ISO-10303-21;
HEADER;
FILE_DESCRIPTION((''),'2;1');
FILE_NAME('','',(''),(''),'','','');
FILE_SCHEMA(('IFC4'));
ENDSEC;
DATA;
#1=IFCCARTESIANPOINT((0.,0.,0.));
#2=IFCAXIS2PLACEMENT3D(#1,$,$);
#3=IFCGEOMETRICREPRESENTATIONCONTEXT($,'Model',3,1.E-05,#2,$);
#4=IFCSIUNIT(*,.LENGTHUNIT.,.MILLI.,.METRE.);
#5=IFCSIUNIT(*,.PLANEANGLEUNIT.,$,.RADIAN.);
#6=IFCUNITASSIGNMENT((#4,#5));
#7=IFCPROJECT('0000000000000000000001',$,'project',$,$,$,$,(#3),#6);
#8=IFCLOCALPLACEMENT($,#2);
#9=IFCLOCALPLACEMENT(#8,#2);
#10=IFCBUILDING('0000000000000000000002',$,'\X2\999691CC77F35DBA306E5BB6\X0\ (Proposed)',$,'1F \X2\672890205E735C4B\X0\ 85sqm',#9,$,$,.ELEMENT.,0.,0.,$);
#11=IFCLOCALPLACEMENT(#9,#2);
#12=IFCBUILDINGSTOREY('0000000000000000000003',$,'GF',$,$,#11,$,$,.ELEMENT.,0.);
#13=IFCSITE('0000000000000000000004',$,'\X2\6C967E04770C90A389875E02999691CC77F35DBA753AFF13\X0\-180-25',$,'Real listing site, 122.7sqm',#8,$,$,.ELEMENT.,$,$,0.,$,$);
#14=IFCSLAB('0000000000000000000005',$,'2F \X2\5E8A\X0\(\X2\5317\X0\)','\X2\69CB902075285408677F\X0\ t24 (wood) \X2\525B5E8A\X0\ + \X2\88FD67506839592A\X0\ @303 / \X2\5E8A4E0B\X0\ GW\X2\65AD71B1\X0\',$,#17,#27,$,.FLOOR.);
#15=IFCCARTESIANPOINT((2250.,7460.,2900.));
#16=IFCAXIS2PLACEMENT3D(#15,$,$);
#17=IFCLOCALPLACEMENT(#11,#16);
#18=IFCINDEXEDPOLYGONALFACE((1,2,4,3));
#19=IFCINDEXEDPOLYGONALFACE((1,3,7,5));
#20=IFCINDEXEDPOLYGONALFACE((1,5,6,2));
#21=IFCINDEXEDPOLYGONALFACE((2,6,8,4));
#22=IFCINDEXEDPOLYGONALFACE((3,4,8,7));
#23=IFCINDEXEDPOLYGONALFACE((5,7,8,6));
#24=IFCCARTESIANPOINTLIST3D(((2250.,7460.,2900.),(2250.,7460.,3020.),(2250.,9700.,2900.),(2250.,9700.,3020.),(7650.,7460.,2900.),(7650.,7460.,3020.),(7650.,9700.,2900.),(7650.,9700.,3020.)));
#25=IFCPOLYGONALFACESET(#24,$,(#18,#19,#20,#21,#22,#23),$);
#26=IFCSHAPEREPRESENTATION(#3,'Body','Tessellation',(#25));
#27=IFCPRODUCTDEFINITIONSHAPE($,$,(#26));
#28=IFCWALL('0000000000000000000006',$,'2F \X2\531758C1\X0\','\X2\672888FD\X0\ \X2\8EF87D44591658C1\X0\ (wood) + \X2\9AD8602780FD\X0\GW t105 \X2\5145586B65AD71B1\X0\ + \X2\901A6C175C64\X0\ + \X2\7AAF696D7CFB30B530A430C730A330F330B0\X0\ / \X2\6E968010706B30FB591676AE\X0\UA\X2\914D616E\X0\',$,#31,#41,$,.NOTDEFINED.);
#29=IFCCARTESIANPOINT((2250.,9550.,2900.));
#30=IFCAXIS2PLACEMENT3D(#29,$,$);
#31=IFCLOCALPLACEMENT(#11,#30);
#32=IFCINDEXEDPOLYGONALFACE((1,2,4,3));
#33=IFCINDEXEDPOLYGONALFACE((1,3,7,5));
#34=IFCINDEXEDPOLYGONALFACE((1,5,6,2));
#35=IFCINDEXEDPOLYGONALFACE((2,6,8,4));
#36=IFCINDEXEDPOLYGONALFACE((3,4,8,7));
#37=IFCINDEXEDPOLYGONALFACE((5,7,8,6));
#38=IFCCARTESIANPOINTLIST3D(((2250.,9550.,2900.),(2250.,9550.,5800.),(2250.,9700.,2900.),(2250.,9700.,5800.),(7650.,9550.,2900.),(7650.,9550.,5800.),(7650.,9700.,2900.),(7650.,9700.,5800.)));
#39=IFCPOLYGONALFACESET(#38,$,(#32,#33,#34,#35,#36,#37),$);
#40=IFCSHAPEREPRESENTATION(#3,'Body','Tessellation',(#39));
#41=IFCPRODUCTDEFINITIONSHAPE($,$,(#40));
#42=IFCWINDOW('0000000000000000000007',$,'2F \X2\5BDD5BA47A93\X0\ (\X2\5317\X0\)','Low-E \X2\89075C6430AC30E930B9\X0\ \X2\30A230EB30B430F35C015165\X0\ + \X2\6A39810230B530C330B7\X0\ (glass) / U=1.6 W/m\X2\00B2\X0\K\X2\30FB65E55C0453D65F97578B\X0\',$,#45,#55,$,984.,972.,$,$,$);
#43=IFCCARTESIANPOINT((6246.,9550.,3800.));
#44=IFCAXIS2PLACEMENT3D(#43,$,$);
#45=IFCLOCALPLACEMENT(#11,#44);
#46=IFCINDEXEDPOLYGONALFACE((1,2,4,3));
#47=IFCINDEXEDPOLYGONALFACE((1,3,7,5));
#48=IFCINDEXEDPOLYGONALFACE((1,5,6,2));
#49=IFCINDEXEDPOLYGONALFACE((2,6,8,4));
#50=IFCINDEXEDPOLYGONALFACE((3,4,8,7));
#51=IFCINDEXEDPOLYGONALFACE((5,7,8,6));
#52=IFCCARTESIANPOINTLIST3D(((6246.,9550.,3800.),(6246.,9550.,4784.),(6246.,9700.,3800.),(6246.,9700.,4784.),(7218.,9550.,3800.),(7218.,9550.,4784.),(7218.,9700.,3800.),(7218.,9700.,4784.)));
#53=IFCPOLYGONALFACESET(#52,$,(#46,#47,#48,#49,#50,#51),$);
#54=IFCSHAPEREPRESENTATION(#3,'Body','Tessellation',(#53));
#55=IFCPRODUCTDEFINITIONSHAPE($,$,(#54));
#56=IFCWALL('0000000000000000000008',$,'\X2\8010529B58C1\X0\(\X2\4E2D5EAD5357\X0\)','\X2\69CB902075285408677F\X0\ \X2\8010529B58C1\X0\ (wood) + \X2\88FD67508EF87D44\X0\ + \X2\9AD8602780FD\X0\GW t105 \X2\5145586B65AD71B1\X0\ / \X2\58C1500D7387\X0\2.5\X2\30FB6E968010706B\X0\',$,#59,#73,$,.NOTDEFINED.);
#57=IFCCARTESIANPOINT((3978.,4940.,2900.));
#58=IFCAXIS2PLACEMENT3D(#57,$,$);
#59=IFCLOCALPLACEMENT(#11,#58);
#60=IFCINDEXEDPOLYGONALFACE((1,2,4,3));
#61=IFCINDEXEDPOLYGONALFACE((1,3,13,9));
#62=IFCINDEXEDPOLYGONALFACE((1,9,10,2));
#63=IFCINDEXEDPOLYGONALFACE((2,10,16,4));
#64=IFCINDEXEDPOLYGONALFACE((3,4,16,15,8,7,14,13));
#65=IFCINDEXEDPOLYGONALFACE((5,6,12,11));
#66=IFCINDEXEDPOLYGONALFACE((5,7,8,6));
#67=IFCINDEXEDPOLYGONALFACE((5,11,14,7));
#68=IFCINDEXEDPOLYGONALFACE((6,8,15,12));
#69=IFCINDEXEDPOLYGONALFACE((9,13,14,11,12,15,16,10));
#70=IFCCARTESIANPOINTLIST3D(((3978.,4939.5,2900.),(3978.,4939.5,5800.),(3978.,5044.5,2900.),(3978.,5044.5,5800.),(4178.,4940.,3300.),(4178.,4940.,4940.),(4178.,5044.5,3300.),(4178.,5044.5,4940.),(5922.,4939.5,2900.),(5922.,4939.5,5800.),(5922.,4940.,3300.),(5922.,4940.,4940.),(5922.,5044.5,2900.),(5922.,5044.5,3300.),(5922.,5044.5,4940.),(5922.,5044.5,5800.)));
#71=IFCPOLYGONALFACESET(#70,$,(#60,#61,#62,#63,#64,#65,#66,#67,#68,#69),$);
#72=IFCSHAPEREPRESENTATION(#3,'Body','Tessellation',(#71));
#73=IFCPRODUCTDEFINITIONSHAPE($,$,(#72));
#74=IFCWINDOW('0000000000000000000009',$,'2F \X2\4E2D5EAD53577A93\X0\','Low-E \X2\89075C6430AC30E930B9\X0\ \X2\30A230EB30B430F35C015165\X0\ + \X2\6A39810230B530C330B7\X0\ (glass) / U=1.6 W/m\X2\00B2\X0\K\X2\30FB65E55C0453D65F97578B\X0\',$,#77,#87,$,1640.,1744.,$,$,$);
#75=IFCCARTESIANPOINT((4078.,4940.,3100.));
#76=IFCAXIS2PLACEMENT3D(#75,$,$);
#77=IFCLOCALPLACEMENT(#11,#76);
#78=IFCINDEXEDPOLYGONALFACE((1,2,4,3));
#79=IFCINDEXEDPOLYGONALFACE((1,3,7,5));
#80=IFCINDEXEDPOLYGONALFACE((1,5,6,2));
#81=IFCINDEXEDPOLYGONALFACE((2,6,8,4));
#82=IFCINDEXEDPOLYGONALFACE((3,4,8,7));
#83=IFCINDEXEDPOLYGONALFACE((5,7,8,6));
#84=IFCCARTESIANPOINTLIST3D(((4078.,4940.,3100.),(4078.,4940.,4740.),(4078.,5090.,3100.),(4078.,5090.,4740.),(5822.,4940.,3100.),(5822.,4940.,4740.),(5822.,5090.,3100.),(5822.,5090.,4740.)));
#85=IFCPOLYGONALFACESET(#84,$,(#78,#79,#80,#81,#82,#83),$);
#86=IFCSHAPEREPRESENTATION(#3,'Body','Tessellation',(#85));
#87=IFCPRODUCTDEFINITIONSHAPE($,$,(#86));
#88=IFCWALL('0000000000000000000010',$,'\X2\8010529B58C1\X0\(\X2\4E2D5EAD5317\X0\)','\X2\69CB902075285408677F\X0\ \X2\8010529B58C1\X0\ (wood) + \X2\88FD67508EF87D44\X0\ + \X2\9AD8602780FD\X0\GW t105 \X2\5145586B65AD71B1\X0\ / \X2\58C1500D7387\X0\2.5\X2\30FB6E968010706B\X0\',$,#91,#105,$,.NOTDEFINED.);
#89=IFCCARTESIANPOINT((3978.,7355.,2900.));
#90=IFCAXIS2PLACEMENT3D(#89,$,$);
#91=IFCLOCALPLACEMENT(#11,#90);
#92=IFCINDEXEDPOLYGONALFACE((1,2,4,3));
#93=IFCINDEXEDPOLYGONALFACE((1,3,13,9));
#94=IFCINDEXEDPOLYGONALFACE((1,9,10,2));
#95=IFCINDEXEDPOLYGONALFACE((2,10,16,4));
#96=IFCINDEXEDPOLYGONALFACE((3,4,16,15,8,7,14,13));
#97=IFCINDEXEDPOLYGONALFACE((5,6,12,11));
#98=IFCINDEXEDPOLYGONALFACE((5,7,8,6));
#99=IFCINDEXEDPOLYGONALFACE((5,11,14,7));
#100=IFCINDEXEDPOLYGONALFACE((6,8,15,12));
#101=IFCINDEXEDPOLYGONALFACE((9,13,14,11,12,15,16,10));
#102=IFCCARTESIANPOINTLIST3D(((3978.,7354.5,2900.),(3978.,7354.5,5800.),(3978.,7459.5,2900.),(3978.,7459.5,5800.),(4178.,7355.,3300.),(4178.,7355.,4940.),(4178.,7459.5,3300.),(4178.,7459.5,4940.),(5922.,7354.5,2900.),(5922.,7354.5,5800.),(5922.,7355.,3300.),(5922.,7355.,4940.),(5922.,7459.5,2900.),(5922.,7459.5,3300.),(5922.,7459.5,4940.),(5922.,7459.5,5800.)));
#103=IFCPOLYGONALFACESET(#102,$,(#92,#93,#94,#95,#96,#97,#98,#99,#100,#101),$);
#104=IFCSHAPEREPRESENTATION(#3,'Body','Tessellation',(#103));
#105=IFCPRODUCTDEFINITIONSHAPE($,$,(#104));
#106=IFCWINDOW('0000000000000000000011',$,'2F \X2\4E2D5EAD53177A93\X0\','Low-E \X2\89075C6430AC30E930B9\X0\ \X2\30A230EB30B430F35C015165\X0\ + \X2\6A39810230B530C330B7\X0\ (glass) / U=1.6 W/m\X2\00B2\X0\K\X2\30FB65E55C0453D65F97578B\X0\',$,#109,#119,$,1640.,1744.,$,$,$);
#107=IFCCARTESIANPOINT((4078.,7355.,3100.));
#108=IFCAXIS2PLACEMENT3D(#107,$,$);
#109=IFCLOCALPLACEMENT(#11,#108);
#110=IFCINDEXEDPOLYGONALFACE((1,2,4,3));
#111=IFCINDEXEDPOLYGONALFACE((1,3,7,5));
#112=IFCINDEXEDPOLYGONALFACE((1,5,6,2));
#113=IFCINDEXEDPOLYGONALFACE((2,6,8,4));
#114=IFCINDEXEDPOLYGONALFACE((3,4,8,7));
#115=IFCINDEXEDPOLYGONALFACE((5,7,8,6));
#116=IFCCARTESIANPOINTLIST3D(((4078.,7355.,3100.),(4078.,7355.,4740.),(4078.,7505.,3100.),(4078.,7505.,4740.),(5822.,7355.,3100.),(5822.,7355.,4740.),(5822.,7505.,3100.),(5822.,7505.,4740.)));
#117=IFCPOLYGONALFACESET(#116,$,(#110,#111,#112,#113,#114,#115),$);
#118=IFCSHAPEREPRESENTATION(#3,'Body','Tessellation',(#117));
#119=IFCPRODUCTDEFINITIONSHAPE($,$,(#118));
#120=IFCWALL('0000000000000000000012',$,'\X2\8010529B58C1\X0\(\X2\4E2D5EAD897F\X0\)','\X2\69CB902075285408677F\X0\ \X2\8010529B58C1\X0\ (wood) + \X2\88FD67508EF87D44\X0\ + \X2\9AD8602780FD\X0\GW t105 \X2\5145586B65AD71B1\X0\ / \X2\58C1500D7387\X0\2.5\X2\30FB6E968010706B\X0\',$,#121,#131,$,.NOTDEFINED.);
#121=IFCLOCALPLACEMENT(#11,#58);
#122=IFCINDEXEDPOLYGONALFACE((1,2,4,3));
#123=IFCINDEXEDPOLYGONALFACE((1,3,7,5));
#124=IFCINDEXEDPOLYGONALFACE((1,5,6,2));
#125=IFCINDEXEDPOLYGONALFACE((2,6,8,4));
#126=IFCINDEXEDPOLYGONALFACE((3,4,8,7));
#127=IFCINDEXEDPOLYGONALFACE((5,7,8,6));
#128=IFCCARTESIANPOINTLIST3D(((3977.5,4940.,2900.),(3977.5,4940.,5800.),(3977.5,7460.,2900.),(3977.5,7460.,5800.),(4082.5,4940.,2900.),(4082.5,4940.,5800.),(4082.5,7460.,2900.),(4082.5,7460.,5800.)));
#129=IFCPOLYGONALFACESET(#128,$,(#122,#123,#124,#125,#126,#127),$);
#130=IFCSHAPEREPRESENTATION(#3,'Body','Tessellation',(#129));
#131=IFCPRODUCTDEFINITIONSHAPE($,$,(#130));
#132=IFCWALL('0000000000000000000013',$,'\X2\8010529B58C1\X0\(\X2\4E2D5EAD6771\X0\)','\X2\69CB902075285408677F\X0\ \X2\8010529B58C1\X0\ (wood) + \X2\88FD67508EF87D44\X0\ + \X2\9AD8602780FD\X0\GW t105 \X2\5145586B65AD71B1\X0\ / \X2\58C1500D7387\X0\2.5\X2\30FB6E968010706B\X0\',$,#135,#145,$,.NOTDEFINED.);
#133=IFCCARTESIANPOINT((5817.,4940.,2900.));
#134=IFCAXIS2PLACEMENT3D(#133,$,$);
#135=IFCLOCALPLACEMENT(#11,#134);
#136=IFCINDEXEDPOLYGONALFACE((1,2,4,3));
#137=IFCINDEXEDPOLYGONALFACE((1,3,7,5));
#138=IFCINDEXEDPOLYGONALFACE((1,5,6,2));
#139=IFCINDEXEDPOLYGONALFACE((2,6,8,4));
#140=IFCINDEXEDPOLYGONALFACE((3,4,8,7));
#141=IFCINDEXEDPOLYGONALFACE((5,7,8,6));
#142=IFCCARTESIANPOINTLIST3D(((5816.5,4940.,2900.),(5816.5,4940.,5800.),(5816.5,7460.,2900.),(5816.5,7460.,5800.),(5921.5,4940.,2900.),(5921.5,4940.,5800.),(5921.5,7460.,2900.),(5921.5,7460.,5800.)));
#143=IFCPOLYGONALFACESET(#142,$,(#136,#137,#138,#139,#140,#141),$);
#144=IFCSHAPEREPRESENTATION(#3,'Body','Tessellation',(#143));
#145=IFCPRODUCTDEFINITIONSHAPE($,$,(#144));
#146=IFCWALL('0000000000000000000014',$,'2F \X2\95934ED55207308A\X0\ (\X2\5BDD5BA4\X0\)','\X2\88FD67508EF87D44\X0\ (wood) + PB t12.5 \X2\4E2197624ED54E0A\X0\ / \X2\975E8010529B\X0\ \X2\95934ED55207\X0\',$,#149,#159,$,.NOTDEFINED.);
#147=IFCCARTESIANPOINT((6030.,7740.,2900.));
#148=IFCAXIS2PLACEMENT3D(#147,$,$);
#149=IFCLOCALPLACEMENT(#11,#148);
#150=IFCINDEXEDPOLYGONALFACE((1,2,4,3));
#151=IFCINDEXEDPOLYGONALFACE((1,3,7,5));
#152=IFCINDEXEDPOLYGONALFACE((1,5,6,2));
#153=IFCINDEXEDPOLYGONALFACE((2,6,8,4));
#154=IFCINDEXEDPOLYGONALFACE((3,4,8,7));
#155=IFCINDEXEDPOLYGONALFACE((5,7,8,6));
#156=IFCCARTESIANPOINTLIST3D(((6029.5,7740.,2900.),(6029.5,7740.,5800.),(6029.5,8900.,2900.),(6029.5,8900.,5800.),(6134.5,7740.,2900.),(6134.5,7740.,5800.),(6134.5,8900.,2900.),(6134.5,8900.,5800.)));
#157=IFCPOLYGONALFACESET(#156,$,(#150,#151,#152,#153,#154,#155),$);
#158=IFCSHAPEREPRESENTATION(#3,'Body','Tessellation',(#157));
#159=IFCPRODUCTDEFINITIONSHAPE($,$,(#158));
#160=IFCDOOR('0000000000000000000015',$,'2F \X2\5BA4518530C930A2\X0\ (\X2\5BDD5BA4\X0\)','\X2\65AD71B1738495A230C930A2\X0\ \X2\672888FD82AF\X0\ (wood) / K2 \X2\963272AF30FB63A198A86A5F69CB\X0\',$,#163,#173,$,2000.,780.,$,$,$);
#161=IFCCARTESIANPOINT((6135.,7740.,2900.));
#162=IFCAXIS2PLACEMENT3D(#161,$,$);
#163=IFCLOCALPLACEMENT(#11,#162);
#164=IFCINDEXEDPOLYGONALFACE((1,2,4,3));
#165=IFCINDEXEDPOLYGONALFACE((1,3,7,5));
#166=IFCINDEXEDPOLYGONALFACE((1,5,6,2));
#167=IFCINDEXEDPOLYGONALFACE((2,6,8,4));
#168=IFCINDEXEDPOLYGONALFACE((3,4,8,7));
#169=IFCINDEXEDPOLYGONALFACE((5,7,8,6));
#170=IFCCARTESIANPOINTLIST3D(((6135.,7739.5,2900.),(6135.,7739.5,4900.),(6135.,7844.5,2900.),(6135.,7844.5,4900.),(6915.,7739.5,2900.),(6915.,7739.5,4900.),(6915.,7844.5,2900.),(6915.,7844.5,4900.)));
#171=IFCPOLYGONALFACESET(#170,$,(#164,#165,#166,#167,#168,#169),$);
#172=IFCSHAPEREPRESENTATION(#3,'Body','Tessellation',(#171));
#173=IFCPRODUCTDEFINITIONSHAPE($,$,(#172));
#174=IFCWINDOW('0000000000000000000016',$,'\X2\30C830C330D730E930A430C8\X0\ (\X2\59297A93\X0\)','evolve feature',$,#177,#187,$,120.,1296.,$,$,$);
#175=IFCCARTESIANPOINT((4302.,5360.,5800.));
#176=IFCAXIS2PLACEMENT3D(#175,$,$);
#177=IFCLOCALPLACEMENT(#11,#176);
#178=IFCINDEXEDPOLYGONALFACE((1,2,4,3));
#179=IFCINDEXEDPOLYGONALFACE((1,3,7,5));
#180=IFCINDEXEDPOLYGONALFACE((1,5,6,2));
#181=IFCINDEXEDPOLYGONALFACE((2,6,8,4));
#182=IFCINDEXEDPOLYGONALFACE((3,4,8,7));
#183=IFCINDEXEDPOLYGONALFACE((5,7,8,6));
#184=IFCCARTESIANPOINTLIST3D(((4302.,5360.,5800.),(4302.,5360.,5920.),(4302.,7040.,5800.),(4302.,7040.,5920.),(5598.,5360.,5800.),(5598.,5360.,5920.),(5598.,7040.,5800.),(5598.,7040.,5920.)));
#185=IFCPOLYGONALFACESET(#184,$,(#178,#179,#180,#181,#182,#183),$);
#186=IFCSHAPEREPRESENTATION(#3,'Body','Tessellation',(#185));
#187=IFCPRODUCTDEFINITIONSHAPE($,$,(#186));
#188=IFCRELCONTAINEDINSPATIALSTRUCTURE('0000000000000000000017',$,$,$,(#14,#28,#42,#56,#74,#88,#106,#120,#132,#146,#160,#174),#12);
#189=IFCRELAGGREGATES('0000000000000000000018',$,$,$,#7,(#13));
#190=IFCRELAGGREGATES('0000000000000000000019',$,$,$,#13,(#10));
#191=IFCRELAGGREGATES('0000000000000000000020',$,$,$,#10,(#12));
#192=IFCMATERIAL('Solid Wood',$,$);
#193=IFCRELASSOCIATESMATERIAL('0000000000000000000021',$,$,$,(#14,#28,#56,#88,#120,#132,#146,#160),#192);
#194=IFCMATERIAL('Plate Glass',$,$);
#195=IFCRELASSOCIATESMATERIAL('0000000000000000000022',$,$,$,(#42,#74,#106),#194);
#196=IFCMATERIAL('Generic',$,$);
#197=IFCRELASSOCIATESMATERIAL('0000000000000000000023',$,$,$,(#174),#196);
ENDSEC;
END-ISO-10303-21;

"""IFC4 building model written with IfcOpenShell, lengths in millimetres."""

from ifc_helpers import new_model, si_unit, frame, frame_2d, origin, place, context, project, spatial, rectangle, extrude, material, element, fill, save


model = new_model("IFC4")

# Units and contexts
model_context = context("Model", 3, precision=1e-05, world=origin())
ifc_project = project(units=[si_unit("LENGTHUNIT", "METRE", prefix="MILLI"), si_unit("PLANEANGLEUNIT", "RADIAN")], contexts=[model_context])

# Site, building, storey
site_placement = place(None, origin())
site = spatial("IfcSite", under=ifc_project, at=site_placement, Name="沖縄県那覇市首里石嶺町３-180-25", ObjectType="Real listing site, 122.7sqm", CompositionType="ELEMENT", RefElevation=0.0)
building_placement = place(site_placement, origin())
building = spatial("IfcBuilding", under=site, at=building_placement, Name="首里石嶺の家 (Proposed)", ObjectType="1F 木造平屋 85sqm", CompositionType="ELEMENT", ElevationOfRefHeight=0.0, ElevationOfTerrain=0.0)
storey_placement = place(building_placement, origin())
storey = spatial("IfcBuildingStorey", under=building, at=storey_placement, Name="GF", CompositionType="ELEMENT", Elevation=0.0)

# Slab
ifc_material_1 = material(Name="Solid Wood")
slab_placement = place(storey_placement, frame((2250.0, 7460.0, 2900.0)))
element("IfcSlab", 1, at=slab_placement, inside=storey, material=ifc_material_1, Name="2F 床(北)", Description="構造用合板 t24 (wood) 剛床 + 製材根太 @303 / 床下 GW断熱", PredefinedType="FLOOR", context=model_context, shape_type="SweptSolid", body=[
    extrude(rectangle(XDim=5400.0, YDim=2240.0, at=frame_2d((2700.0, 1120.0))), frame((2250.0, 7460.0, 2900.0)), (0.0, 0.0, 1.0), 120.0),
])

# Walls, openings, windows
wall_1_placement = place(storey_placement, frame((2250.0, 9550.0, 2900.0)))
wall_1 = element("IfcWall", 2, at=wall_1_placement, inside=storey, material=ifc_material_1, Name="2F 北壁", Description="木製 軸組外壁 (wood) + 高性能GW t105 充填断熱 + 通気層 + 窯業系サイディング / 準耐火・外皮UA配慮", PredefinedType="NOTDEFINED", context=model_context, shape_type="SweptSolid", body=[
    extrude(rectangle(XDim=5400.0, YDim=150.0, at=frame_2d((2700.0, 75.0))), frame((2250.0, 9550.0, 2900.0)), (0.0, 0.0, 1.0), 2900.0),
])
opening_1_placement = place(storey_placement, frame((6246.0, 9550.0, 3800.0)))
opening_1 = element("IfcOpeningElement", 3, at=opening_1_placement, cuts=wall_1, PredefinedType="NOTDEFINED", context=model_context, shape_type="SweptSolid", body=[
    extrude(rectangle(XDim=972.0, YDim=150.0, at=frame_2d((486.0, 75.0))), frame((6246.0, 9550.0, 3800.0)), (0.0, 0.0, 1.0), 984.0),
])
ifc_material_2 = material(Name="Plate Glass")
window_1_placement = place(storey_placement, frame((6246.0, 9550.0, 3800.0)))
window_1 = element("IfcWindow", 4, at=window_1_placement, inside=storey, material=ifc_material_2, Name="2F 寝室窓 (北)", Description="Low-E 複層ガラス アルゴン封入 + 樹脂サッシ (glass) / U=1.6 W/m²K・日射取得型", OverallHeight=984.0, OverallWidth=972.0, context=model_context, shape_type="SweptSolid", body=[
    extrude(rectangle(XDim=972.0, YDim=150.0, at=frame_2d((486.0, 75.0))), frame((6246.0, 9550.0, 3800.0)), (0.0, 0.0, 1.0), 984.0),
])
fill(opening_1, window_1)
wall_2_placement = place(storey_placement, frame((3978.0, 4940.0, 2900.0)))
wall_2 = element("IfcWall", 5, at=wall_2_placement, inside=storey, material=ifc_material_1, Name="耐力壁(中庭南)", Description="構造用合板 耐力壁 (wood) + 製材軸組 + 高性能GW t105 充填断熱 / 壁倍率2.5・準耐火", PredefinedType="NOTDEFINED", context=model_context, shape_type="SweptSolid", body=[
    extrude(rectangle(XDim=1944.0, YDim=105.0, at=frame_2d((972.0, 52.0))), frame((3978.0, 4940.0, 2900.0)), (0.0, 0.0, 1.0), 2900.0),
])
opening_2_placement = place(storey_placement, frame((4078.0, 4940.0, 3100.0)))
opening_2 = element("IfcOpeningElement", 6, at=opening_2_placement, cuts=wall_2, PredefinedType="NOTDEFINED", context=model_context, shape_type="SweptSolid", body=[
    extrude(rectangle(XDim=1744.0, YDim=150.0, at=frame_2d((872.0, 75.0))), frame((4078.0, 4940.0, 3100.0)), (0.0, 0.0, 1.0), 1640.0),
])
window_2_placement = place(storey_placement, frame((4078.0, 4940.0, 3100.0)))
window_2 = element("IfcWindow", 7, at=window_2_placement, inside=storey, material=ifc_material_2, Name="2F 中庭南窓", Description="Low-E 複層ガラス アルゴン封入 + 樹脂サッシ (glass) / U=1.6 W/m²K・日射取得型", OverallHeight=1640.0, OverallWidth=1744.0, context=model_context, shape_type="SweptSolid", body=[
    extrude(rectangle(XDim=1744.0, YDim=150.0, at=frame_2d((872.0, 75.0))), frame((4078.0, 4940.0, 3100.0)), (0.0, 0.0, 1.0), 1640.0),
])
fill(opening_2, window_2)
wall_3_placement = place(storey_placement, frame((3978.0, 7355.0, 2900.0)))
wall_3 = element("IfcWall", 8, at=wall_3_placement, inside=storey, material=ifc_material_1, Name="耐力壁(中庭北)", Description="構造用合板 耐力壁 (wood) + 製材軸組 + 高性能GW t105 充填断熱 / 壁倍率2.5・準耐火", PredefinedType="NOTDEFINED", context=model_context, shape_type="SweptSolid", body=[
    extrude(rectangle(XDim=1944.0, YDim=105.0, at=frame_2d((972.0, 52.0))), frame((3978.0, 7355.0, 2900.0)), (0.0, 0.0, 1.0), 2900.0),
])
opening_3_placement = place(storey_placement, frame((4078.0, 7355.0, 3100.0)))
opening_3 = element("IfcOpeningElement", 9, at=opening_3_placement, cuts=wall_3, PredefinedType="NOTDEFINED", context=model_context, shape_type="SweptSolid", body=[
    extrude(rectangle(XDim=1744.0, YDim=150.0, at=frame_2d((872.0, 75.0))), frame((4078.0, 7355.0, 3100.0)), (0.0, 0.0, 1.0), 1640.0),
])
window_3_placement = place(storey_placement, frame((4078.0, 7355.0, 3100.0)))
window_3 = element("IfcWindow", 10, at=window_3_placement, inside=storey, material=ifc_material_2, Name="2F 中庭北窓", Description="Low-E 複層ガラス アルゴン封入 + 樹脂サッシ (glass) / U=1.6 W/m²K・日射取得型", OverallHeight=1640.0, OverallWidth=1744.0, context=model_context, shape_type="SweptSolid", body=[
    extrude(rectangle(XDim=1744.0, YDim=150.0, at=frame_2d((872.0, 75.0))), frame((4078.0, 7355.0, 3100.0)), (0.0, 0.0, 1.0), 1640.0),
])
fill(opening_3, window_3)

# Walls
wall_4_placement = place(storey_placement, frame((3978.0, 4940.0, 2900.0)))
element("IfcWall", 11, at=wall_4_placement, inside=storey, material=ifc_material_1, Name="耐力壁(中庭西)", Description="構造用合板 耐力壁 (wood) + 製材軸組 + 高性能GW t105 充填断熱 / 壁倍率2.5・準耐火", PredefinedType="NOTDEFINED", context=model_context, shape_type="SweptSolid", body=[
    extrude(rectangle(XDim=105.0, YDim=2520.0, at=frame_2d((52.0, 1260.0))), frame((3978.0, 4940.0, 2900.0)), (0.0, 0.0, 1.0), 2900.0),
])
wall_5_placement = place(storey_placement, frame((5817.0, 4940.0, 2900.0)))
element("IfcWall", 12, at=wall_5_placement, inside=storey, material=ifc_material_1, Name="耐力壁(中庭東)", Description="構造用合板 耐力壁 (wood) + 製材軸組 + 高性能GW t105 充填断熱 / 壁倍率2.5・準耐火", PredefinedType="NOTDEFINED", context=model_context, shape_type="SweptSolid", body=[
    extrude(rectangle(XDim=105.0, YDim=2520.0, at=frame_2d((52.0, 1260.0))), frame((5817.0, 4940.0, 2900.0)), (0.0, 0.0, 1.0), 2900.0),
])
wall_6_placement = place(storey_placement, frame((6030.0, 7740.0, 2900.0)))
element("IfcWall", 13, at=wall_6_placement, inside=storey, material=ifc_material_1, Name="2F 間仕切り (寝室)", Description="製材軸組 (wood) + PB t12.5 両面仕上 / 非耐力 間仕切", PredefinedType="NOTDEFINED", context=model_context, shape_type="SweptSolid", body=[
    extrude(rectangle(XDim=105.0, YDim=1160.0, at=frame_2d((52.0, 580.0))), frame((6030.0, 7740.0, 2900.0)), (0.0, 0.0, 1.0), 2900.0),
])

# Door
door_placement = place(storey_placement, frame((6135.0, 7740.0, 2900.0)))
element("IfcDoor", 14, at=door_placement, inside=storey, material=ifc_material_1, Name="2F 室内ドア (寝室)", Description="断熱玄関ドア 木製芯 (wood) / K2 防犯・採風機構", OverallHeight=2000.0, OverallWidth=780.0, context=model_context, shape_type="SweptSolid", body=[
    extrude(rectangle(XDim=780.0, YDim=105.0, at=frame_2d((390.0, 52.0))), frame((6135.0, 7740.0, 2900.0)), (0.0, 0.0, 1.0), 2000.0),
])

# Window
ifc_material_3 = material(Name="Generic")
window_4_placement = place(storey_placement, frame((4302.0, 5360.0, 5800.0)))
element("IfcWindow", 15, at=window_4_placement, inside=storey, material=ifc_material_3, Name="トップライト (天窓)", Description="evolve feature", OverallHeight=120.0, OverallWidth=1296.0, context=model_context, shape_type="SweptSolid", body=[
    extrude(rectangle(XDim=1296.0, YDim=1680.0, at=frame_2d((648.0, 840.0))), frame((4302.0, 5360.0, 5800.0)), (0.0, 0.0, 1.0), 120.0),
])

save(model, "model.ifc")
